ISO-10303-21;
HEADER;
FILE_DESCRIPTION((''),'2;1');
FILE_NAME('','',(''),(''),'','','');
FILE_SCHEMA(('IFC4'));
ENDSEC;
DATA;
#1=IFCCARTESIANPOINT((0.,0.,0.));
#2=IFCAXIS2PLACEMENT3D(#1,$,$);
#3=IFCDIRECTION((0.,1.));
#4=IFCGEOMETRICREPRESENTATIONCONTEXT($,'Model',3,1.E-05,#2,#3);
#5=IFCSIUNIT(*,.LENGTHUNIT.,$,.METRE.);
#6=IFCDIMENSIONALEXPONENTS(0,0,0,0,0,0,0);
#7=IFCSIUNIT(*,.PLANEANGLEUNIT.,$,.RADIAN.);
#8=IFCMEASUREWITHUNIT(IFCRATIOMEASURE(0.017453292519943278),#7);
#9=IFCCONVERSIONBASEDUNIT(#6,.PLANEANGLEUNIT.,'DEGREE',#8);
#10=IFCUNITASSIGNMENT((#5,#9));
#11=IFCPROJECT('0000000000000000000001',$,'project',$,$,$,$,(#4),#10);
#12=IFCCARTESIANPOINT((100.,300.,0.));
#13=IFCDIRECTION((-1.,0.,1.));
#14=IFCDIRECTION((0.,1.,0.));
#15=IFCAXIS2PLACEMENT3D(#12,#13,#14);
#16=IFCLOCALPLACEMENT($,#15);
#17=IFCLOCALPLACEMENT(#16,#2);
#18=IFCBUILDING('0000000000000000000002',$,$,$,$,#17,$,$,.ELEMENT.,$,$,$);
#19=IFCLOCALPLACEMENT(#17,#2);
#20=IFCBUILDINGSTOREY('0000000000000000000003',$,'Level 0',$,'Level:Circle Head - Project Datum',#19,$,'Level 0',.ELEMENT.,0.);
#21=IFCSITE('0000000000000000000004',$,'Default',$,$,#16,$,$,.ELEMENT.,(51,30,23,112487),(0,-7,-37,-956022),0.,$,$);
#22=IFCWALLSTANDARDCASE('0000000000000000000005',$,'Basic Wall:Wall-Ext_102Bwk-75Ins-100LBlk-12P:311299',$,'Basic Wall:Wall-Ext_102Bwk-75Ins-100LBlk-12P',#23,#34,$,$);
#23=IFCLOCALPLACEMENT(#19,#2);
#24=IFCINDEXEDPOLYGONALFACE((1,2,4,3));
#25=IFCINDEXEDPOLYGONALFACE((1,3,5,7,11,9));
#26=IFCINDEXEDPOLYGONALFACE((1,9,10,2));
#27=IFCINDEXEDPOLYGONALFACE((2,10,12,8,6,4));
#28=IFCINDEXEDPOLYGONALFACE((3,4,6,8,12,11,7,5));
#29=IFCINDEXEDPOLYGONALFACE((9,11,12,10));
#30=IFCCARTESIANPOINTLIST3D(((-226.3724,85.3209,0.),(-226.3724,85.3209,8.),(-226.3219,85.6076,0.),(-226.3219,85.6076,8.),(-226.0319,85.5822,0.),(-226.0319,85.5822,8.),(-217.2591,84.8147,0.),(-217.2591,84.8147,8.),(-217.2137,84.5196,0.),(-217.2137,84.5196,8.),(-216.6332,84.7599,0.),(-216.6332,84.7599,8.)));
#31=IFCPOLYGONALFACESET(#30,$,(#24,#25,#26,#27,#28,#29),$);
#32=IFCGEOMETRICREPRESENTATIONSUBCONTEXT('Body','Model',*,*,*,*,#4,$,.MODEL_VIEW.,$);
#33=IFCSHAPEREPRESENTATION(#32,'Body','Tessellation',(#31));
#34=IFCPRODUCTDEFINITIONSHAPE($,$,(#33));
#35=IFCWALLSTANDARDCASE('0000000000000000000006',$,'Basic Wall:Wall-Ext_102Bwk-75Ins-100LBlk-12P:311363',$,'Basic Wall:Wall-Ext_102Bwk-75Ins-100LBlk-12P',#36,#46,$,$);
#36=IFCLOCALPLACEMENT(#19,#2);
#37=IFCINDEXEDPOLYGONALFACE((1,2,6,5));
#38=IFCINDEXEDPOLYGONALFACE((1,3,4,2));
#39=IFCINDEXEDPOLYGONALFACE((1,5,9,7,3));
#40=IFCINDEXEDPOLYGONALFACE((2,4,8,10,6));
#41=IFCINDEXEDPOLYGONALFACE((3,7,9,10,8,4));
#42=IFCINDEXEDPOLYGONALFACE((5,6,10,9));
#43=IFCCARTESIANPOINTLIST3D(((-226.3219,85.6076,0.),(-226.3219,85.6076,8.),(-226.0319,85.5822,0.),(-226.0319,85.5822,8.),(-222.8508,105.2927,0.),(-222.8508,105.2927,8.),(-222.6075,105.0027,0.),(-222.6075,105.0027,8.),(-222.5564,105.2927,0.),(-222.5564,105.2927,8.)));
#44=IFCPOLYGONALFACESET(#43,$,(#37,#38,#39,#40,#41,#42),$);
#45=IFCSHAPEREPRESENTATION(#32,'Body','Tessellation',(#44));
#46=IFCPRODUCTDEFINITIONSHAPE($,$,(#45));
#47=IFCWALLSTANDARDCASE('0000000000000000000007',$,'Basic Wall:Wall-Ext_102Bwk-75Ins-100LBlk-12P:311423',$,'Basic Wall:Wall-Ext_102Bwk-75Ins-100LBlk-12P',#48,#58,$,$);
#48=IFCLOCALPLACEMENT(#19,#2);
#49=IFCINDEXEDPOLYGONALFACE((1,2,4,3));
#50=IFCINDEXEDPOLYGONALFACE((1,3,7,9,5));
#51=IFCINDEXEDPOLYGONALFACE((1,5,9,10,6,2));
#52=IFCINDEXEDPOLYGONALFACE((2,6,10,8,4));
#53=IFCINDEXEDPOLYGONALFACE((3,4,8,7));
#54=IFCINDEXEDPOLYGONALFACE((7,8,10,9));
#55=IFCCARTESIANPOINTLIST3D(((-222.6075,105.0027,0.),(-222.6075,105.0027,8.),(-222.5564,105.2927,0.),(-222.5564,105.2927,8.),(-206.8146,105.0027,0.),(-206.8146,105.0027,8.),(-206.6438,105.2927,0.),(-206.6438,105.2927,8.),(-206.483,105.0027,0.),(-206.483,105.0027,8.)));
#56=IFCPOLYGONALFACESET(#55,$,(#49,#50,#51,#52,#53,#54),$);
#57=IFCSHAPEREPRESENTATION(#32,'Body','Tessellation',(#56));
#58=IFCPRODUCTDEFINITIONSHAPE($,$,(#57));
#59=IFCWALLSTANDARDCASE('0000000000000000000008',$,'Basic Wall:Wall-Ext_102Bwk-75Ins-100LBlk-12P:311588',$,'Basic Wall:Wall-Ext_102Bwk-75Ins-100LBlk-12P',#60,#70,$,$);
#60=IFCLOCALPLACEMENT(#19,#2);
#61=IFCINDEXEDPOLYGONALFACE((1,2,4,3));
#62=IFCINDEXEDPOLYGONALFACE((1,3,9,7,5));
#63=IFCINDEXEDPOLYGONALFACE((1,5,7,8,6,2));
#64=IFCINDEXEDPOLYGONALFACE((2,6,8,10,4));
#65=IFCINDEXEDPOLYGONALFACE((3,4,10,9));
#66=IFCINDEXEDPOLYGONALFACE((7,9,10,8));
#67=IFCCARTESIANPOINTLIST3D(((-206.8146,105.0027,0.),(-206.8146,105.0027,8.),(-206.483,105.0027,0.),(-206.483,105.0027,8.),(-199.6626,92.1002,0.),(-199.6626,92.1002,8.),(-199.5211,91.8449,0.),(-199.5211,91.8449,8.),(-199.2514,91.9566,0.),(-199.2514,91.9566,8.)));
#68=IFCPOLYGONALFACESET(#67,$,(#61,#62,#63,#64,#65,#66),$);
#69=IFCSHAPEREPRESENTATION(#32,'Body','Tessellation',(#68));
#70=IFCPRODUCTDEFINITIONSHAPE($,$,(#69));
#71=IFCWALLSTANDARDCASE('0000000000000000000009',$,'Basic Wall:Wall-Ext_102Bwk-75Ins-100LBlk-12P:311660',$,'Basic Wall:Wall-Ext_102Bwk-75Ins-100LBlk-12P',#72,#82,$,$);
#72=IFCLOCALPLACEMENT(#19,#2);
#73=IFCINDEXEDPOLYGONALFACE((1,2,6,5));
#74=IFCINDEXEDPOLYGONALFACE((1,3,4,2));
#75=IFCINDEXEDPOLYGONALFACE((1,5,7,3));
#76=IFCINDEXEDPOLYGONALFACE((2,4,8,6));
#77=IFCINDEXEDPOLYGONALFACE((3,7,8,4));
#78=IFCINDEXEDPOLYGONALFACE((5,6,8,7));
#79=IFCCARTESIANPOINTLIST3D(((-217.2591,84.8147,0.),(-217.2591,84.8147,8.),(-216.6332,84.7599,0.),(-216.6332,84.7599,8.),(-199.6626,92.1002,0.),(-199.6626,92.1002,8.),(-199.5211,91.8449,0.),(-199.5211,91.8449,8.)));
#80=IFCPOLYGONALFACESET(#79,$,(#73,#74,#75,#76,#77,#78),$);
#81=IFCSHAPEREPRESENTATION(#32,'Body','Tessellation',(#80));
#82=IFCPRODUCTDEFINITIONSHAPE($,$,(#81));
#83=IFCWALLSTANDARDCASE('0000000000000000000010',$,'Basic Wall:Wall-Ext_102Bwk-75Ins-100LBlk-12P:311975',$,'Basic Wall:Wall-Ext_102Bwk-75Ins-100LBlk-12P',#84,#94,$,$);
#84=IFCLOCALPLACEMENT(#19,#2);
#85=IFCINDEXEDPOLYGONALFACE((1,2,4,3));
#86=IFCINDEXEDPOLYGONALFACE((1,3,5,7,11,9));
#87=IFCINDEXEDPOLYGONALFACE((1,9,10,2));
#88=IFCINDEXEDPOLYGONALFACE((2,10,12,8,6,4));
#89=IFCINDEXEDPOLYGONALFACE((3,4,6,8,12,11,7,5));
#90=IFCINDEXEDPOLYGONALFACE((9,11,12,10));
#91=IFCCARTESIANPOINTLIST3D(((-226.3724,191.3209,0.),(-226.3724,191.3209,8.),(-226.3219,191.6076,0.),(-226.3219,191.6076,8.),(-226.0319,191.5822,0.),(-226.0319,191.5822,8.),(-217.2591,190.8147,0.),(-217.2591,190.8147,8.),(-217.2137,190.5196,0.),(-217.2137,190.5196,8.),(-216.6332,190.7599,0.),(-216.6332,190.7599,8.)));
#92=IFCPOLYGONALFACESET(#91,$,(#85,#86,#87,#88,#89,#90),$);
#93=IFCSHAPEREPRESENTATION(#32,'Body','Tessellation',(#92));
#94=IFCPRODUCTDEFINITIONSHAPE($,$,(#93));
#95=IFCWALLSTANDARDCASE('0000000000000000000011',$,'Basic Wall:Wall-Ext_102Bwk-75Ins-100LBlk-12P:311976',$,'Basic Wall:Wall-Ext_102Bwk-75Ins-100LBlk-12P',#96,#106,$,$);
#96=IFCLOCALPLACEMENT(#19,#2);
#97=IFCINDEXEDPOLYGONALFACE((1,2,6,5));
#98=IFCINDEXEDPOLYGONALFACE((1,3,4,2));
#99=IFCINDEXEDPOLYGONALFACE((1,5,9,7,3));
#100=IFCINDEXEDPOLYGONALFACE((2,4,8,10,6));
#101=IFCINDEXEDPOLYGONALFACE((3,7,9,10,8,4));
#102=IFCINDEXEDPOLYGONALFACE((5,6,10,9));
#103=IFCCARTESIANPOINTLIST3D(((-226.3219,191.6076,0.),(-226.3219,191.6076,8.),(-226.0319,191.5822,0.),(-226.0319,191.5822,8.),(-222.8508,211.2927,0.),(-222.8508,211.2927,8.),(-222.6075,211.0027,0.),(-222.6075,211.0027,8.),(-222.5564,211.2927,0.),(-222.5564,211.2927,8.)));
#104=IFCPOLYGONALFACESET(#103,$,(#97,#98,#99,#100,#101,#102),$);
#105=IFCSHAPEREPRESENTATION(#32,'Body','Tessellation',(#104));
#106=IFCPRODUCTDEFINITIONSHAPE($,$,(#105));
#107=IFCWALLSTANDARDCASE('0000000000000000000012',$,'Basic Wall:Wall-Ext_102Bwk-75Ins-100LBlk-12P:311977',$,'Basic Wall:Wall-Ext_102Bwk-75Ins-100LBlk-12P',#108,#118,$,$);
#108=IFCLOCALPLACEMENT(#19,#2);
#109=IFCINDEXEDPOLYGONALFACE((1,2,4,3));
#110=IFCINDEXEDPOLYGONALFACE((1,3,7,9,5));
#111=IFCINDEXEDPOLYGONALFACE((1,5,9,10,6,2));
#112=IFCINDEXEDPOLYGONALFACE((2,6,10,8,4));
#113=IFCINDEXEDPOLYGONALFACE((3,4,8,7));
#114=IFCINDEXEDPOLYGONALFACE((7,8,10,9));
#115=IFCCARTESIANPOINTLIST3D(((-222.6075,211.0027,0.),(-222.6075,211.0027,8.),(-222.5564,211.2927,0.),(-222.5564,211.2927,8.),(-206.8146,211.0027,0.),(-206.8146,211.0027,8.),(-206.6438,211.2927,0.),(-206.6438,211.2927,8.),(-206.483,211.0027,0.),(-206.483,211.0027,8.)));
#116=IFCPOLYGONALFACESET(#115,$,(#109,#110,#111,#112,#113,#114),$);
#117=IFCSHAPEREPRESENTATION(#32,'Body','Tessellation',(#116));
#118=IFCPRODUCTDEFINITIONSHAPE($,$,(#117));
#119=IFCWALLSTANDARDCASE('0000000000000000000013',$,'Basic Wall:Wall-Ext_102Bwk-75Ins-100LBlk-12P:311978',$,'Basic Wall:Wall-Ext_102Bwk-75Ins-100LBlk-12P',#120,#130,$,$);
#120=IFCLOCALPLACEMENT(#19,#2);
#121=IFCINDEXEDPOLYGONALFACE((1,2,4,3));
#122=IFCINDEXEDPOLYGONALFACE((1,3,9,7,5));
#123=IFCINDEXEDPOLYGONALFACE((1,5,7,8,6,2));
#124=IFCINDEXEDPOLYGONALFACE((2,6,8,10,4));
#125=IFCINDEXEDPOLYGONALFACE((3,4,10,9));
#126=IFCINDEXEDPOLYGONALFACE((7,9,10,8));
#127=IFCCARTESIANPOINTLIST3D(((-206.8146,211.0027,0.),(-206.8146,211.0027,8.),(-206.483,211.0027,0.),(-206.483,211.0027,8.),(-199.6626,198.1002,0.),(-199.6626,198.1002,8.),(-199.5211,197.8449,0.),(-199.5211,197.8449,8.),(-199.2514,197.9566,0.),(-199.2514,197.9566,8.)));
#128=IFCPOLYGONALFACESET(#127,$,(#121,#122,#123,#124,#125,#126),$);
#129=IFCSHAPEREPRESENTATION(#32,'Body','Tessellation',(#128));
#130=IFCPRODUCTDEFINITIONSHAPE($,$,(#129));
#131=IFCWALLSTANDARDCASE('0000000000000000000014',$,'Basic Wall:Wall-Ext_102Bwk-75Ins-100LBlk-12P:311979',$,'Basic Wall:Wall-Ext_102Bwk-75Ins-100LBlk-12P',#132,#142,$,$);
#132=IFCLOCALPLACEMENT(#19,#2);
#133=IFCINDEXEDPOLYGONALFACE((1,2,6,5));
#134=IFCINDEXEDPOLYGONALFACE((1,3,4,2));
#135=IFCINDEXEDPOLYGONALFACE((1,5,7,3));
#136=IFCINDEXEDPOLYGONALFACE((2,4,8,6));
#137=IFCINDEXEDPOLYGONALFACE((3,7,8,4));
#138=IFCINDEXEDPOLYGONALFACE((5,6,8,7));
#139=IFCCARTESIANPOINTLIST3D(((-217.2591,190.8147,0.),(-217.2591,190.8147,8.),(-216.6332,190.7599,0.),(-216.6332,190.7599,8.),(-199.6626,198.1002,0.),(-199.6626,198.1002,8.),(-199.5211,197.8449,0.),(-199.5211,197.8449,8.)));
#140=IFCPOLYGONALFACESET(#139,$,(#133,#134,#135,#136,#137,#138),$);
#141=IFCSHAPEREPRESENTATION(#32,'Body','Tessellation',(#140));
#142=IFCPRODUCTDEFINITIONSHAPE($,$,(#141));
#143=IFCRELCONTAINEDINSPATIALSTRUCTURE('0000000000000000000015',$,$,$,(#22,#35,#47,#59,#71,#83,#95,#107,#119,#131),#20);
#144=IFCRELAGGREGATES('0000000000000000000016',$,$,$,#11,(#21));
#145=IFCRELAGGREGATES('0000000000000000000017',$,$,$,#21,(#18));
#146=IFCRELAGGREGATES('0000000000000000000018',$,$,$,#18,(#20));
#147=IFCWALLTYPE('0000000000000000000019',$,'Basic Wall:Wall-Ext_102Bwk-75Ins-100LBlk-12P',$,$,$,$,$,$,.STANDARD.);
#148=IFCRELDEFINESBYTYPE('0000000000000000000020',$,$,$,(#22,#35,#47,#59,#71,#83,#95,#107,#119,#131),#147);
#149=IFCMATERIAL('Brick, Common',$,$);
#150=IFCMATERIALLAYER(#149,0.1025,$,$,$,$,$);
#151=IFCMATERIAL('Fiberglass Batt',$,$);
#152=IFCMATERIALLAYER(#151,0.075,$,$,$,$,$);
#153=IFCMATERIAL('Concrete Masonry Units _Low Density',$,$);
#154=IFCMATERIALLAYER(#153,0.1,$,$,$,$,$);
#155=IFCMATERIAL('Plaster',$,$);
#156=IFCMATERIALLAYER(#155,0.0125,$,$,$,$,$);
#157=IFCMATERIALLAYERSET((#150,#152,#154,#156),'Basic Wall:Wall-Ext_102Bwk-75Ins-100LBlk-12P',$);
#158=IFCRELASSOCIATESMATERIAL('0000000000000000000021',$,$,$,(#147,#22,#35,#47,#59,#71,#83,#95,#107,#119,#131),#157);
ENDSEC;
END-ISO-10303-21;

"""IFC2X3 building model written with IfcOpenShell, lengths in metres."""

from ifc_helpers import new_model, entity, si_unit, converted_unit, direction, frame, origin, place, context, subcontext, project, spatial, polyline, outline, extrude, material, layer, layer_set, layer_usage, type_object, element, save


model = new_model("IFC2X3")

# Units and contexts
model_context = context("Model", 3, precision=1e-05, world=origin(), true_north=direction((0.0, 1.0)))
body_context = subcontext(model_context, "Body", "Model", "MODEL_VIEW")
ifc_project = project(units=[si_unit("LENGTHUNIT", "METRE"), converted_unit("PLANEANGLEUNIT", "DEGREE", entity("IfcRatioMeasure", 0.017453292519943278), si_unit("PLANEANGLEUNIT", "RADIAN"), dimensions=[0, 0, 0, 0, 0, 0, 0])], contexts=[model_context])

# Site, building, storey
site_placement = place(None, frame((100.0, 300.0, 0.0), z_axis=(-1.0, 0.0, 1.0), x_axis=(0.0, 1.0, 0.0)))
site = spatial("IfcSite", under=ifc_project, at=site_placement, Name="Default", CompositionType="ELEMENT", RefLatitude=(51, 30, 23, 112487), RefLongitude=(0, -7, -37, -956022), RefElevation=0.0)
building_placement = place(site_placement, origin())
building = spatial("IfcBuilding", under=site, at=building_placement, CompositionType="ELEMENT")
storey_placement = place(building_placement, origin())
storey = spatial("IfcBuildingStorey", under=building, at=storey_placement, Name="Level 0", ObjectType="Level:Circle Head - Project Datum", LongName="Level 0", CompositionType="ELEMENT", Elevation=0.0)

# Walls
ifc_material_1 = material(Name="Brick, Common")
ifc_layer_1 = layer(ifc_material_1, 0.1025)
ifc_material_2 = material(Name="Fiberglass Batt")
ifc_layer_2 = layer(ifc_material_2, 0.075)
ifc_material_3 = material(Name="Concrete Masonry Units _Low Density")
ifc_layer_3 = layer(ifc_material_3, 0.1)
ifc_material_4 = material(Name="Plaster")
ifc_layer_4 = layer(ifc_material_4, 0.0125)
ifc_layer_set = layer_set([ifc_layer_1, ifc_layer_2, ifc_layer_3, ifc_layer_4], Name="Basic Wall:Wall-Ext_102Bwk-75Ins-100LBlk-12P")
ifc_layer_usage_1 = layer_usage(ifc_layer_set, "AXIS2", "NEGATIVE", 0.145)
wall_type = type_object("IfcWallType", Name="Basic Wall:Wall-Ext_102Bwk-75Ins-100LBlk-12P", PredefinedType="STANDARD", material=ifc_layer_set)
wall_1_placement = place(storey_placement, frame((-216.6459, 84.6155, 0.0), z_axis=(0.0, 0.0, 1.0), x_axis=(-0.996195, 0.087156, 0.0)))
element("IfcWallStandardCase", 1, at=wall_1_placement, inside=storey, type_object=wall_type, material=ifc_layer_usage_1, Name="Basic Wall:Wall-Ext_102Bwk-75Ins-100LBlk-12P:311299", ObjectType="Basic Wall:Wall-Ext_102Bwk-75Ins-100LBlk-12P", context=body_context, shape_type="SweptSolid", body=[
    extrude(outline(polyline([(9.7256, -0.145), (9.751, 0.145), (0.5573, 0.145), (0.0, -0.145), (0.6282, -0.145), (9.4345, -0.145), (9.7256, -0.145)])), origin(), (0.0, 0.0, 1.0), 8.0),
])
ifc_layer_usage_2 = layer_usage(ifc_layer_set, "AXIS2", "NEGATIVE", 0.145)
wall_2_placement = place(storey_placement, frame((-226.1791, 85.5824, 0.0), z_axis=(0.0, 0.0, 1.0), x_axis=(0.173648, 0.984808, 0.0)))
element("IfcWallStandardCase", 2, at=wall_2_placement, inside=storey, type_object=wall_type, material=ifc_layer_usage_2, Name="Basic Wall:Wall-Ext_102Bwk-75Ins-100LBlk-12P:311363", ObjectType="Basic Wall:Wall-Ext_102Bwk-75Ins-100LBlk-12P", context=body_context, shape_type="SweptSolid", body=[
    extrude(outline(polyline([(20.0399, -0.145), (19.9888, 0.145), (0.0, 0.145), (0.0254, -0.145), (19.7455, -0.145), (20.0399, -0.145)])), origin(), (0.0, 0.0, 1.0), 8.0),
])
ifc_layer_usage_3 = layer_usage(ifc_layer_set, "AXIS2", "NEGATIVE", 0.145)
wall_3_placement = place(storey_placement, frame((-222.6075, 105.1477, 0.0)))
element("IfcWallStandardCase", 3, at=wall_3_placement, inside=storey, type_object=wall_type, material=ifc_layer_usage_3, Name="Basic Wall:Wall-Ext_102Bwk-75Ins-100LBlk-12P:311423", ObjectType="Basic Wall:Wall-Ext_102Bwk-75Ins-100LBlk-12P", context=body_context, shape_type="SweptSolid", body=[
    extrude(outline(polyline([(16.1245, -0.145), (15.9637, 0.145), (0.0511, 0.145), (0.0, -0.145), (15.7929, -0.145), (16.1245, -0.145)])), origin(), (0.0, 0.0, 1.0), 8.0),
])
ifc_layer_usage_4 = layer_usage(ifc_layer_set, "AXIS2", "NEGATIVE", 0.145)
wall_4_placement = place(storey_placement, frame((-206.6878, 105.073, 0.0), z_axis=(0.0, 0.0, 1.0), x_axis=(0.48481, -0.87462, 0.0)))
element("IfcWallStandardCase", 4, at=wall_4_placement, inside=storey, type_object=wall_type, material=ifc_layer_usage_4, Name="Basic Wall:Wall-Ext_102Bwk-75Ins-100LBlk-12P:311588", ObjectType="Basic Wall:Wall-Ext_102Bwk-75Ins-100LBlk-12P", context=body_context, shape_type="SweptSolid", body=[
    extrude(outline(polyline([(15.044, -0.145), (15.0771, 0.145), (0.1607, 0.145), (0.0, -0.145), (14.7521, -0.145), (15.044, -0.145)])), origin(), (0.0, 0.0, 1.0), 8.0),
])
ifc_layer_usage_5 = layer_usage(ifc_layer_set, "AXIS2", "NEGATIVE", 0.145)
wall_5_placement = place(storey_placement, frame((-199.5766, 91.9789, 0.0), z_axis=(0.0, 0.0, 1.0), x_axis=(-0.923938, -0.382542, 0.0)))
element("IfcWallStandardCase", 5, at=wall_5_placement, inside=storey, type_object=wall_type, material=ifc_layer_usage_5, Name="Basic Wall:Wall-Ext_102Bwk-75Ins-100LBlk-12P:311660", ObjectType="Basic Wall:Wall-Ext_102Bwk-75Ins-100LBlk-12P", context=body_context, shape_type="SweptSolid", body=[
    extrude(outline(polyline([(19.0781, -0.145), (18.5209, 0.145), (0.0, 0.145), (0.0331, -0.145), (19.0781, -0.145)])), origin(), (0.0, 0.0, 1.0), 8.0),
])
ifc_layer_usage_6 = layer_usage(ifc_layer_set, "AXIS2", "NEGATIVE", 0.145)
wall_6_placement = place(storey_placement, frame((-216.6459, 190.6155, 0.0), z_axis=(0.0, 0.0, 1.0), x_axis=(-0.996195, 0.087156, 0.0)))
element("IfcWallStandardCase", 6, at=wall_6_placement, inside=storey, type_object=wall_type, material=ifc_layer_usage_6, Name="Basic Wall:Wall-Ext_102Bwk-75Ins-100LBlk-12P:311975", ObjectType="Basic Wall:Wall-Ext_102Bwk-75Ins-100LBlk-12P", context=body_context, shape_type="SweptSolid", body=[
    extrude(outline(polyline([(9.7256, -0.145), (9.751, 0.145), (0.5573, 0.145), (0.0, -0.145), (0.6282, -0.145), (9.4345, -0.145), (9.7256, -0.145)])), origin(), (0.0, 0.0, 1.0), 8.0),
])
ifc_layer_usage_7 = layer_usage(ifc_layer_set, "AXIS2", "NEGATIVE", 0.145)
wall_7_placement = place(storey_placement, frame((-226.1791, 191.5824, 0.0), z_axis=(0.0, 0.0, 1.0), x_axis=(0.173648, 0.984808, 0.0)))
element("IfcWallStandardCase", 7, at=wall_7_placement, inside=storey, type_object=wall_type, material=ifc_layer_usage_7, Name="Basic Wall:Wall-Ext_102Bwk-75Ins-100LBlk-12P:311976", ObjectType="Basic Wall:Wall-Ext_102Bwk-75Ins-100LBlk-12P", context=body_context, shape_type="SweptSolid", body=[
    extrude(outline(polyline([(20.0399, -0.145), (19.9888, 0.145), (0.0, 0.145), (0.0254, -0.145), (19.7455, -0.145), (20.0399, -0.145)])), origin(), (0.0, 0.0, 1.0), 8.0),
])
ifc_layer_usage_8 = layer_usage(ifc_layer_set, "AXIS2", "NEGATIVE", 0.145)
wall_8_placement = place(storey_placement, frame((-222.6075, 211.1477, 0.0)))
element("IfcWallStandardCase", 8, at=wall_8_placement, inside=storey, type_object=wall_type, material=ifc_layer_usage_8, Name="Basic Wall:Wall-Ext_102Bwk-75Ins-100LBlk-12P:311977", ObjectType="Basic Wall:Wall-Ext_102Bwk-75Ins-100LBlk-12P", context=body_context, shape_type="SweptSolid", body=[
    extrude(outline(polyline([(16.1245, -0.145), (15.9637, 0.145), (0.0511, 0.145), (0.0, -0.145), (15.7929, -0.145), (16.1245, -0.145)])), origin(), (0.0, 0.0, 1.0), 8.0),
])
ifc_layer_usage_9 = layer_usage(ifc_layer_set, "AXIS2", "NEGATIVE", 0.145)
wall_9_placement = place(storey_placement, frame((-206.6878, 211.073, 0.0), z_axis=(0.0, 0.0, 1.0), x_axis=(0.48481, -0.87462, 0.0)))
element("IfcWallStandardCase", 9, at=wall_9_placement, inside=storey, type_object=wall_type, material=ifc_layer_usage_9, Name="Basic Wall:Wall-Ext_102Bwk-75Ins-100LBlk-12P:311978", ObjectType="Basic Wall:Wall-Ext_102Bwk-75Ins-100LBlk-12P", context=body_context, shape_type="SweptSolid", body=[
    extrude(outline(polyline([(15.044, -0.145), (15.0771, 0.145), (0.1607, 0.145), (0.0, -0.145), (14.7521, -0.145), (15.044, -0.145)])), origin(), (0.0, 0.0, 1.0), 8.0),
])
ifc_layer_usage_10 = layer_usage(ifc_layer_set, "AXIS2", "NEGATIVE", 0.145)
wall_10_placement = place(storey_placement, frame((-199.5766, 197.9789, 0.0), z_axis=(0.0, 0.0, 1.0), x_axis=(-0.923938, -0.382542, 0.0)))
element("IfcWallStandardCase", 10, at=wall_10_placement, inside=storey, type_object=wall_type, material=ifc_layer_usage_10, Name="Basic Wall:Wall-Ext_102Bwk-75Ins-100LBlk-12P:311979", ObjectType="Basic Wall:Wall-Ext_102Bwk-75Ins-100LBlk-12P", context=body_context, shape_type="SweptSolid", body=[
    extrude(outline(polyline([(19.0781, -0.145), (18.5209, 0.145), (0.0, 0.145), (0.0331, -0.145), (19.0781, -0.145)])), origin(), (0.0, 0.0, 1.0), 8.0),
])

save(model, "model.ifc")
